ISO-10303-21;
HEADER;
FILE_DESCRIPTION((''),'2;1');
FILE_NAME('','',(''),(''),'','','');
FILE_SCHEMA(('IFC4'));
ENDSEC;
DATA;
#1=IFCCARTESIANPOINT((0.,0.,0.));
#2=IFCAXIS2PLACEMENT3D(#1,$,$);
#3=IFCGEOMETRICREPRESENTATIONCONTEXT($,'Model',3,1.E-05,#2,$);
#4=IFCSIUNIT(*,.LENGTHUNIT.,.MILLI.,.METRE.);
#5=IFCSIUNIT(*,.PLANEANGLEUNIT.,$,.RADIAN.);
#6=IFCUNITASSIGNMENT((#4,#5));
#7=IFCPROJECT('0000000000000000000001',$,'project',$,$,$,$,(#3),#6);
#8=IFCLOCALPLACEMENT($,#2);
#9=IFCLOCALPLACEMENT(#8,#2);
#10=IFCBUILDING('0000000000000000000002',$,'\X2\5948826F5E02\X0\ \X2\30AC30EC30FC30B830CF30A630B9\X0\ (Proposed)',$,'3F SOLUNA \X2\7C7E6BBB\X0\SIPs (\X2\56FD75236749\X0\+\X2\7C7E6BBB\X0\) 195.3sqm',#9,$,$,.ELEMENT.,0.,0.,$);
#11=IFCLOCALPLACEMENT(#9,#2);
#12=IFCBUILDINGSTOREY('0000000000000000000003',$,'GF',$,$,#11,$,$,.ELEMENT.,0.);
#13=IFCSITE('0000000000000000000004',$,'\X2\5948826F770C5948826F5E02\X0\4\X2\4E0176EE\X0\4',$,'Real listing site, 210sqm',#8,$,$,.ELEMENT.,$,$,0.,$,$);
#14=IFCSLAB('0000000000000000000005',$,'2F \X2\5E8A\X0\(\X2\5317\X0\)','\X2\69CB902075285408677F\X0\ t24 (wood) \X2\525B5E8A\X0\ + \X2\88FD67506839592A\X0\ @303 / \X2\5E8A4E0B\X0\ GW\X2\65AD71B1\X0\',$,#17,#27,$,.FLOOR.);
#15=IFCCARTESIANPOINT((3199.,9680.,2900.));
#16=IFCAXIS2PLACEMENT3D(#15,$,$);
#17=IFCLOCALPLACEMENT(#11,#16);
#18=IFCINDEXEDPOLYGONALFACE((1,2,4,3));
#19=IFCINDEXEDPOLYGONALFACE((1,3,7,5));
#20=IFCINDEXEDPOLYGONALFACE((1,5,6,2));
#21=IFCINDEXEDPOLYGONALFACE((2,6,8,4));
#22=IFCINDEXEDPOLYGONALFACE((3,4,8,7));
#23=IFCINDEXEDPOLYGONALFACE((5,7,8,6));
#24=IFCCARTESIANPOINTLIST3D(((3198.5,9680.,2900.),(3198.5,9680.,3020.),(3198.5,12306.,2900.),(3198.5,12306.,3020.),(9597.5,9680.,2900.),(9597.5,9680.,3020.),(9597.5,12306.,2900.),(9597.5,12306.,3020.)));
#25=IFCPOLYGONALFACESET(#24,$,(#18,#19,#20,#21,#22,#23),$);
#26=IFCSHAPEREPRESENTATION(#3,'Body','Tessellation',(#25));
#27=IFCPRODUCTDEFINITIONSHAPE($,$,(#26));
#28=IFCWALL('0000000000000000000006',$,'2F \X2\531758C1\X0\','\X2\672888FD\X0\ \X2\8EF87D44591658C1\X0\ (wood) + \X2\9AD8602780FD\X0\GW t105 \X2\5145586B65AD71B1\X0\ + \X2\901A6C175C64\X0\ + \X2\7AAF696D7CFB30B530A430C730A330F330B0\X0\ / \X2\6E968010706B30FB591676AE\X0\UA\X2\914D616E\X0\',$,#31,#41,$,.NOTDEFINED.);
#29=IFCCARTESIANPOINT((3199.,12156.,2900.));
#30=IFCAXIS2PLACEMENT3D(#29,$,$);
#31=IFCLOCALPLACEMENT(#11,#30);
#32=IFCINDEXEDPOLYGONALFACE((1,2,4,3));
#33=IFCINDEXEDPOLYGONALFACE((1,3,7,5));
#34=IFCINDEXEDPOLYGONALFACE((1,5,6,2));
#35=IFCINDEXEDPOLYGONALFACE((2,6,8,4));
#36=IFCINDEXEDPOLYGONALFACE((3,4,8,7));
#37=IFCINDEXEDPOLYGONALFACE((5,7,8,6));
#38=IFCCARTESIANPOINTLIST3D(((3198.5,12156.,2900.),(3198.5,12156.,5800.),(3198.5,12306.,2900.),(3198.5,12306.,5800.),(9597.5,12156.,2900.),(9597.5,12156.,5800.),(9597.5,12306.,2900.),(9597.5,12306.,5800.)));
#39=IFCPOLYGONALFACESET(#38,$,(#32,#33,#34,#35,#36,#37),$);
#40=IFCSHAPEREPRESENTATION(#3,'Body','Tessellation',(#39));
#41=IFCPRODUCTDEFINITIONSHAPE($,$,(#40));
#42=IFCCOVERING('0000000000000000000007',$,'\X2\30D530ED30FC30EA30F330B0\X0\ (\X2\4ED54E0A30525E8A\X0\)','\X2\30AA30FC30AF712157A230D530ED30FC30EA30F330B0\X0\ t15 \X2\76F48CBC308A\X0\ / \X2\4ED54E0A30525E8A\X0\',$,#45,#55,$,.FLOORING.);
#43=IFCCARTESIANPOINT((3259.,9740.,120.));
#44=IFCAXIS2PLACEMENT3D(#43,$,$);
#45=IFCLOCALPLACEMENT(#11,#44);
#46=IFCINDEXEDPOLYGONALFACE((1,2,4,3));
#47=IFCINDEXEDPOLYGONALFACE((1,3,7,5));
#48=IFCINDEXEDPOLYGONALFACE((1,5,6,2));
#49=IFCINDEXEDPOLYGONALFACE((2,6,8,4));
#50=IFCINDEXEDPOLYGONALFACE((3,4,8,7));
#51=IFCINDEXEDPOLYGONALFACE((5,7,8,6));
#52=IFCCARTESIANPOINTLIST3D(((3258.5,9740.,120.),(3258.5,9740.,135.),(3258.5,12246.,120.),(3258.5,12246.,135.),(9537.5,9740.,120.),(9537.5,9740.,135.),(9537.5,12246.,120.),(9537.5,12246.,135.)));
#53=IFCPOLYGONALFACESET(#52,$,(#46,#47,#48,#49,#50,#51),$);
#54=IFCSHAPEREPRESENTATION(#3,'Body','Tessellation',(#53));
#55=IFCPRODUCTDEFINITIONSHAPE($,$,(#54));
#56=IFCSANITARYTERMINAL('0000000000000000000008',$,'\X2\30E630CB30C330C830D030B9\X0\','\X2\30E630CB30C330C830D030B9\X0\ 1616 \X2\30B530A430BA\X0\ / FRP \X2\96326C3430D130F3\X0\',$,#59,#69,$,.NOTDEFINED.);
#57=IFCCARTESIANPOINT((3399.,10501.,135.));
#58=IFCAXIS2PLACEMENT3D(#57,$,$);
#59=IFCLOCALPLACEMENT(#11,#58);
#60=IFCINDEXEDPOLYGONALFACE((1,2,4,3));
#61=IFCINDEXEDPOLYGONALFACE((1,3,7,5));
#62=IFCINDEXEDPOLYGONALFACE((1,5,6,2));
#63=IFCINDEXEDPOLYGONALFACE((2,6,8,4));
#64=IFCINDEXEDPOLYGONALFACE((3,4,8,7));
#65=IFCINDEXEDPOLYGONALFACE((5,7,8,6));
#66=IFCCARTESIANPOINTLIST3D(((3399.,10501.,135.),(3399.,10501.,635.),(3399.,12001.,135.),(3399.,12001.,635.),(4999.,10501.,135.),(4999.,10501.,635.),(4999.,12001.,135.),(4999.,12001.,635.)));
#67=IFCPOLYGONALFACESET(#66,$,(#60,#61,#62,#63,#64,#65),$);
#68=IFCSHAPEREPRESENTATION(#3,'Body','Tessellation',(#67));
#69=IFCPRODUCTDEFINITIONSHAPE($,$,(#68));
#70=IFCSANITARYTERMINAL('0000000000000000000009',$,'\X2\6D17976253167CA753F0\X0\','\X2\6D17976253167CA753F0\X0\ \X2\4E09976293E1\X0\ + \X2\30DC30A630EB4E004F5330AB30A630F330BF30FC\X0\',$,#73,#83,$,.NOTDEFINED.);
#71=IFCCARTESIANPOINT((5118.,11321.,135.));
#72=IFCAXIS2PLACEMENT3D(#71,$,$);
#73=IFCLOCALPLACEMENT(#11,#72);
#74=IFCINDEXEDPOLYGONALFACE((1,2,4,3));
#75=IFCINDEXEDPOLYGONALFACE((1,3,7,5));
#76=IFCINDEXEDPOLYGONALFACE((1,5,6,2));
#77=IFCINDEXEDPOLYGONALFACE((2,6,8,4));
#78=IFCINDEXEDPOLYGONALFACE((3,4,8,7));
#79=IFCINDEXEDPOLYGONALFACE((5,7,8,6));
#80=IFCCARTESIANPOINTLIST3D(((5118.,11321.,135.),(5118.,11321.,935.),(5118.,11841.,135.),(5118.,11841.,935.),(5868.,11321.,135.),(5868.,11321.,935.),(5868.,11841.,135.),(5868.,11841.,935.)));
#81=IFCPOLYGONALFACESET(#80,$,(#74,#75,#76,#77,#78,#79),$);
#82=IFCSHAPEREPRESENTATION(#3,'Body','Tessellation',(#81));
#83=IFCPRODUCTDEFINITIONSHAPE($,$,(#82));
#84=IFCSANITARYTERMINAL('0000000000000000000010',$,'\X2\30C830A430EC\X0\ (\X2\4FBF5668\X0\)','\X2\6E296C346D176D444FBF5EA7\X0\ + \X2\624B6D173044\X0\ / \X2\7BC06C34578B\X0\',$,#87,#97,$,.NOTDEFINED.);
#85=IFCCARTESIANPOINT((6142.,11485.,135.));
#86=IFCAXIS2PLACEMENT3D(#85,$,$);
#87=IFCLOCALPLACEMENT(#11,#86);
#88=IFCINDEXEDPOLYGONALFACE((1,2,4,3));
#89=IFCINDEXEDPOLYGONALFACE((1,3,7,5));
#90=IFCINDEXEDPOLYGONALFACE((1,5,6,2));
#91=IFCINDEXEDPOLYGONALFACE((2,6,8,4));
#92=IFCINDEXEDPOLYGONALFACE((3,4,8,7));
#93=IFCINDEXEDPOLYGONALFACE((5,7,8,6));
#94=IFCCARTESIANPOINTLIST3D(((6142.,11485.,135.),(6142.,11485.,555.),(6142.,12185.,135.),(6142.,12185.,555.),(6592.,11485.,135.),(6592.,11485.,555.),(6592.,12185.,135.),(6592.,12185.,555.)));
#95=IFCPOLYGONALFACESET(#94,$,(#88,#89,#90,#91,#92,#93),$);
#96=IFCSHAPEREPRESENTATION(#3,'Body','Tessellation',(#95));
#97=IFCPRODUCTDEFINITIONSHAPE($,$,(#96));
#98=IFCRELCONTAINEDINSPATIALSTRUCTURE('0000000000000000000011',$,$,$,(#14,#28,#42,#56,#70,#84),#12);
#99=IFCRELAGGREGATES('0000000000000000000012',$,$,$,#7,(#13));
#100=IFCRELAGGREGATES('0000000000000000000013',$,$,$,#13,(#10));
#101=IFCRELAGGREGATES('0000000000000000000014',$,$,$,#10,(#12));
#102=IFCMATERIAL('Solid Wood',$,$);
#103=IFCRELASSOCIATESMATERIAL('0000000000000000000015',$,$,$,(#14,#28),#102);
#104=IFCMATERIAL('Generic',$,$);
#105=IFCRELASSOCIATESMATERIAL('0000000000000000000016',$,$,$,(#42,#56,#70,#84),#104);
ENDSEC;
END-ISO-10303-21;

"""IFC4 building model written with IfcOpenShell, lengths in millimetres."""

from ifc_helpers import new_model, si_unit, frame, frame_2d, origin, place, context, project, spatial, rectangle, extrude, material, element, save


model = new_model("IFC4")

# Units and contexts
model_context = context("Model", 3, precision=1e-05, world=origin())
ifc_project = project(units=[si_unit("LENGTHUNIT", "METRE", prefix="MILLI"), si_unit("PLANEANGLEUNIT", "RADIAN")], contexts=[model_context])

# Site, building, storey
site_placement = place(None, origin())
site = spatial("IfcSite", under=ifc_project, at=site_placement, Name="奈良県奈良市4丁目4", ObjectType="Real listing site, 210sqm", CompositionType="ELEMENT", RefElevation=0.0)
building_placement = place(site_placement, origin())
building = spatial("IfcBuilding", under=site, at=building_placement, Name="奈良市 ガレージハウス (Proposed)", ObjectType="3F SOLUNA 籾殻SIPs (国産杉+籾殻) 195.3sqm", CompositionType="ELEMENT", ElevationOfRefHeight=0.0, ElevationOfTerrain=0.0)
storey_placement = place(building_placement, origin())
storey = spatial("IfcBuildingStorey", under=building, at=storey_placement, Name="GF", CompositionType="ELEMENT", Elevation=0.0)

# Slab
ifc_material_1 = material(Name="Solid Wood")
slab_1_placement = place(storey_placement, frame((3199.0, 9680.0, 2900.0)))
element("IfcSlab", 1, at=slab_1_placement, inside=storey, material=ifc_material_1, Name="2F 床(北)", Description="構造用合板 t24 (wood) 剛床 + 製材根太 @303 / 床下 GW断熱", PredefinedType="FLOOR", context=model_context, shape_type="SweptSolid", body=[
    extrude(rectangle(XDim=6399.0, YDim=2626.0, at=frame_2d((3199.0, 1313.0))), frame((3199.0, 9680.0, 2900.0)), (0.0, 0.0, 1.0), 120.0),
])

# Wall
wall_1_placement = place(storey_placement, frame((3199.0, 12156.0, 2900.0)))
element("IfcWall", 2, at=wall_1_placement, inside=storey, material=ifc_material_1, Name="2F 北壁", Description="木製 軸組外壁 (wood) + 高性能GW t105 充填断熱 + 通気層 + 窯業系サイディング / 準耐火・外皮UA配慮", PredefinedType="NOTDEFINED", context=model_context, shape_type="SweptSolid", body=[
    extrude(rectangle(XDim=6399.0, YDim=150.0, at=frame_2d((3199.0, 75.0))), frame((3199.0, 12156.0, 2900.0)), (0.0, 0.0, 1.0), 2900.0),
])

# Covering
ifc_material_2 = material(Name="Generic")
covering_1_placement = place(storey_placement, frame((3259.0, 9740.0, 120.0)))
element("IfcCovering", 3, at=covering_1_placement, inside=storey, material=ifc_material_2, Name="フローリング (仕上げ床)", Description="オーク無垢フローリング t15 直貼り / 仕上げ床", PredefinedType="FLOORING", context=model_context, shape_type="SweptSolid", body=[
    extrude(rectangle(XDim=6279.0, YDim=2506.0, at=frame_2d((3139.0, 1253.0))), frame((3259.0, 9740.0, 120.0)), (0.0, 0.0, 1.0), 15.0),
])

# Sanitary terminals
sanitary_terminal_1_placement = place(storey_placement, frame((3399.0, 10501.0, 135.0)))
element("IfcSanitaryTerminal", 4, at=sanitary_terminal_1_placement, inside=storey, material=ifc_material_2, Name="ユニットバス", Description="ユニットバス 1616 サイズ / FRP 防水パン", PredefinedType="NOTDEFINED", context=model_context, shape_type="SweptSolid", body=[
    extrude(rectangle(XDim=1600.0, YDim=1500.0, at=frame_2d((800.0, 750.0))), frame((3399.0, 10501.0, 135.0)), (0.0, 0.0, 1.0), 500.0),
])
sanitary_terminal_2_placement = place(storey_placement, frame((5118.0, 11321.0, 135.0)))
element("IfcSanitaryTerminal", 5, at=sanitary_terminal_2_placement, inside=storey, material=ifc_material_2, Name="洗面化粧台", Description="洗面化粧台 三面鏡 + ボウル一体カウンター", PredefinedType="NOTDEFINED", context=model_context, shape_type="SweptSolid", body=[
    extrude(rectangle(XDim=750.0, YDim=520.0, at=frame_2d((375.0, 260.0))), frame((5118.0, 11321.0, 135.0)), (0.0, 0.0, 1.0), 800.0),
])
sanitary_terminal_3_placement = place(storey_placement, frame((6142.0, 11485.0, 135.0)))
element("IfcSanitaryTerminal", 6, at=sanitary_terminal_3_placement, inside=storey, material=ifc_material_2, Name="トイレ (便器)", Description="温水洗浄便座 + 手洗い / 節水型", PredefinedType="NOTDEFINED", context=model_context, shape_type="SweptSolid", body=[
    extrude(rectangle(XDim=450.0, YDim=700.0, at=frame_2d((225.0, 350.0))), frame((6142.0, 11485.0, 135.0)), (0.0, 0.0, 1.0), 420.0),
])

save(model, "model.ifc")
